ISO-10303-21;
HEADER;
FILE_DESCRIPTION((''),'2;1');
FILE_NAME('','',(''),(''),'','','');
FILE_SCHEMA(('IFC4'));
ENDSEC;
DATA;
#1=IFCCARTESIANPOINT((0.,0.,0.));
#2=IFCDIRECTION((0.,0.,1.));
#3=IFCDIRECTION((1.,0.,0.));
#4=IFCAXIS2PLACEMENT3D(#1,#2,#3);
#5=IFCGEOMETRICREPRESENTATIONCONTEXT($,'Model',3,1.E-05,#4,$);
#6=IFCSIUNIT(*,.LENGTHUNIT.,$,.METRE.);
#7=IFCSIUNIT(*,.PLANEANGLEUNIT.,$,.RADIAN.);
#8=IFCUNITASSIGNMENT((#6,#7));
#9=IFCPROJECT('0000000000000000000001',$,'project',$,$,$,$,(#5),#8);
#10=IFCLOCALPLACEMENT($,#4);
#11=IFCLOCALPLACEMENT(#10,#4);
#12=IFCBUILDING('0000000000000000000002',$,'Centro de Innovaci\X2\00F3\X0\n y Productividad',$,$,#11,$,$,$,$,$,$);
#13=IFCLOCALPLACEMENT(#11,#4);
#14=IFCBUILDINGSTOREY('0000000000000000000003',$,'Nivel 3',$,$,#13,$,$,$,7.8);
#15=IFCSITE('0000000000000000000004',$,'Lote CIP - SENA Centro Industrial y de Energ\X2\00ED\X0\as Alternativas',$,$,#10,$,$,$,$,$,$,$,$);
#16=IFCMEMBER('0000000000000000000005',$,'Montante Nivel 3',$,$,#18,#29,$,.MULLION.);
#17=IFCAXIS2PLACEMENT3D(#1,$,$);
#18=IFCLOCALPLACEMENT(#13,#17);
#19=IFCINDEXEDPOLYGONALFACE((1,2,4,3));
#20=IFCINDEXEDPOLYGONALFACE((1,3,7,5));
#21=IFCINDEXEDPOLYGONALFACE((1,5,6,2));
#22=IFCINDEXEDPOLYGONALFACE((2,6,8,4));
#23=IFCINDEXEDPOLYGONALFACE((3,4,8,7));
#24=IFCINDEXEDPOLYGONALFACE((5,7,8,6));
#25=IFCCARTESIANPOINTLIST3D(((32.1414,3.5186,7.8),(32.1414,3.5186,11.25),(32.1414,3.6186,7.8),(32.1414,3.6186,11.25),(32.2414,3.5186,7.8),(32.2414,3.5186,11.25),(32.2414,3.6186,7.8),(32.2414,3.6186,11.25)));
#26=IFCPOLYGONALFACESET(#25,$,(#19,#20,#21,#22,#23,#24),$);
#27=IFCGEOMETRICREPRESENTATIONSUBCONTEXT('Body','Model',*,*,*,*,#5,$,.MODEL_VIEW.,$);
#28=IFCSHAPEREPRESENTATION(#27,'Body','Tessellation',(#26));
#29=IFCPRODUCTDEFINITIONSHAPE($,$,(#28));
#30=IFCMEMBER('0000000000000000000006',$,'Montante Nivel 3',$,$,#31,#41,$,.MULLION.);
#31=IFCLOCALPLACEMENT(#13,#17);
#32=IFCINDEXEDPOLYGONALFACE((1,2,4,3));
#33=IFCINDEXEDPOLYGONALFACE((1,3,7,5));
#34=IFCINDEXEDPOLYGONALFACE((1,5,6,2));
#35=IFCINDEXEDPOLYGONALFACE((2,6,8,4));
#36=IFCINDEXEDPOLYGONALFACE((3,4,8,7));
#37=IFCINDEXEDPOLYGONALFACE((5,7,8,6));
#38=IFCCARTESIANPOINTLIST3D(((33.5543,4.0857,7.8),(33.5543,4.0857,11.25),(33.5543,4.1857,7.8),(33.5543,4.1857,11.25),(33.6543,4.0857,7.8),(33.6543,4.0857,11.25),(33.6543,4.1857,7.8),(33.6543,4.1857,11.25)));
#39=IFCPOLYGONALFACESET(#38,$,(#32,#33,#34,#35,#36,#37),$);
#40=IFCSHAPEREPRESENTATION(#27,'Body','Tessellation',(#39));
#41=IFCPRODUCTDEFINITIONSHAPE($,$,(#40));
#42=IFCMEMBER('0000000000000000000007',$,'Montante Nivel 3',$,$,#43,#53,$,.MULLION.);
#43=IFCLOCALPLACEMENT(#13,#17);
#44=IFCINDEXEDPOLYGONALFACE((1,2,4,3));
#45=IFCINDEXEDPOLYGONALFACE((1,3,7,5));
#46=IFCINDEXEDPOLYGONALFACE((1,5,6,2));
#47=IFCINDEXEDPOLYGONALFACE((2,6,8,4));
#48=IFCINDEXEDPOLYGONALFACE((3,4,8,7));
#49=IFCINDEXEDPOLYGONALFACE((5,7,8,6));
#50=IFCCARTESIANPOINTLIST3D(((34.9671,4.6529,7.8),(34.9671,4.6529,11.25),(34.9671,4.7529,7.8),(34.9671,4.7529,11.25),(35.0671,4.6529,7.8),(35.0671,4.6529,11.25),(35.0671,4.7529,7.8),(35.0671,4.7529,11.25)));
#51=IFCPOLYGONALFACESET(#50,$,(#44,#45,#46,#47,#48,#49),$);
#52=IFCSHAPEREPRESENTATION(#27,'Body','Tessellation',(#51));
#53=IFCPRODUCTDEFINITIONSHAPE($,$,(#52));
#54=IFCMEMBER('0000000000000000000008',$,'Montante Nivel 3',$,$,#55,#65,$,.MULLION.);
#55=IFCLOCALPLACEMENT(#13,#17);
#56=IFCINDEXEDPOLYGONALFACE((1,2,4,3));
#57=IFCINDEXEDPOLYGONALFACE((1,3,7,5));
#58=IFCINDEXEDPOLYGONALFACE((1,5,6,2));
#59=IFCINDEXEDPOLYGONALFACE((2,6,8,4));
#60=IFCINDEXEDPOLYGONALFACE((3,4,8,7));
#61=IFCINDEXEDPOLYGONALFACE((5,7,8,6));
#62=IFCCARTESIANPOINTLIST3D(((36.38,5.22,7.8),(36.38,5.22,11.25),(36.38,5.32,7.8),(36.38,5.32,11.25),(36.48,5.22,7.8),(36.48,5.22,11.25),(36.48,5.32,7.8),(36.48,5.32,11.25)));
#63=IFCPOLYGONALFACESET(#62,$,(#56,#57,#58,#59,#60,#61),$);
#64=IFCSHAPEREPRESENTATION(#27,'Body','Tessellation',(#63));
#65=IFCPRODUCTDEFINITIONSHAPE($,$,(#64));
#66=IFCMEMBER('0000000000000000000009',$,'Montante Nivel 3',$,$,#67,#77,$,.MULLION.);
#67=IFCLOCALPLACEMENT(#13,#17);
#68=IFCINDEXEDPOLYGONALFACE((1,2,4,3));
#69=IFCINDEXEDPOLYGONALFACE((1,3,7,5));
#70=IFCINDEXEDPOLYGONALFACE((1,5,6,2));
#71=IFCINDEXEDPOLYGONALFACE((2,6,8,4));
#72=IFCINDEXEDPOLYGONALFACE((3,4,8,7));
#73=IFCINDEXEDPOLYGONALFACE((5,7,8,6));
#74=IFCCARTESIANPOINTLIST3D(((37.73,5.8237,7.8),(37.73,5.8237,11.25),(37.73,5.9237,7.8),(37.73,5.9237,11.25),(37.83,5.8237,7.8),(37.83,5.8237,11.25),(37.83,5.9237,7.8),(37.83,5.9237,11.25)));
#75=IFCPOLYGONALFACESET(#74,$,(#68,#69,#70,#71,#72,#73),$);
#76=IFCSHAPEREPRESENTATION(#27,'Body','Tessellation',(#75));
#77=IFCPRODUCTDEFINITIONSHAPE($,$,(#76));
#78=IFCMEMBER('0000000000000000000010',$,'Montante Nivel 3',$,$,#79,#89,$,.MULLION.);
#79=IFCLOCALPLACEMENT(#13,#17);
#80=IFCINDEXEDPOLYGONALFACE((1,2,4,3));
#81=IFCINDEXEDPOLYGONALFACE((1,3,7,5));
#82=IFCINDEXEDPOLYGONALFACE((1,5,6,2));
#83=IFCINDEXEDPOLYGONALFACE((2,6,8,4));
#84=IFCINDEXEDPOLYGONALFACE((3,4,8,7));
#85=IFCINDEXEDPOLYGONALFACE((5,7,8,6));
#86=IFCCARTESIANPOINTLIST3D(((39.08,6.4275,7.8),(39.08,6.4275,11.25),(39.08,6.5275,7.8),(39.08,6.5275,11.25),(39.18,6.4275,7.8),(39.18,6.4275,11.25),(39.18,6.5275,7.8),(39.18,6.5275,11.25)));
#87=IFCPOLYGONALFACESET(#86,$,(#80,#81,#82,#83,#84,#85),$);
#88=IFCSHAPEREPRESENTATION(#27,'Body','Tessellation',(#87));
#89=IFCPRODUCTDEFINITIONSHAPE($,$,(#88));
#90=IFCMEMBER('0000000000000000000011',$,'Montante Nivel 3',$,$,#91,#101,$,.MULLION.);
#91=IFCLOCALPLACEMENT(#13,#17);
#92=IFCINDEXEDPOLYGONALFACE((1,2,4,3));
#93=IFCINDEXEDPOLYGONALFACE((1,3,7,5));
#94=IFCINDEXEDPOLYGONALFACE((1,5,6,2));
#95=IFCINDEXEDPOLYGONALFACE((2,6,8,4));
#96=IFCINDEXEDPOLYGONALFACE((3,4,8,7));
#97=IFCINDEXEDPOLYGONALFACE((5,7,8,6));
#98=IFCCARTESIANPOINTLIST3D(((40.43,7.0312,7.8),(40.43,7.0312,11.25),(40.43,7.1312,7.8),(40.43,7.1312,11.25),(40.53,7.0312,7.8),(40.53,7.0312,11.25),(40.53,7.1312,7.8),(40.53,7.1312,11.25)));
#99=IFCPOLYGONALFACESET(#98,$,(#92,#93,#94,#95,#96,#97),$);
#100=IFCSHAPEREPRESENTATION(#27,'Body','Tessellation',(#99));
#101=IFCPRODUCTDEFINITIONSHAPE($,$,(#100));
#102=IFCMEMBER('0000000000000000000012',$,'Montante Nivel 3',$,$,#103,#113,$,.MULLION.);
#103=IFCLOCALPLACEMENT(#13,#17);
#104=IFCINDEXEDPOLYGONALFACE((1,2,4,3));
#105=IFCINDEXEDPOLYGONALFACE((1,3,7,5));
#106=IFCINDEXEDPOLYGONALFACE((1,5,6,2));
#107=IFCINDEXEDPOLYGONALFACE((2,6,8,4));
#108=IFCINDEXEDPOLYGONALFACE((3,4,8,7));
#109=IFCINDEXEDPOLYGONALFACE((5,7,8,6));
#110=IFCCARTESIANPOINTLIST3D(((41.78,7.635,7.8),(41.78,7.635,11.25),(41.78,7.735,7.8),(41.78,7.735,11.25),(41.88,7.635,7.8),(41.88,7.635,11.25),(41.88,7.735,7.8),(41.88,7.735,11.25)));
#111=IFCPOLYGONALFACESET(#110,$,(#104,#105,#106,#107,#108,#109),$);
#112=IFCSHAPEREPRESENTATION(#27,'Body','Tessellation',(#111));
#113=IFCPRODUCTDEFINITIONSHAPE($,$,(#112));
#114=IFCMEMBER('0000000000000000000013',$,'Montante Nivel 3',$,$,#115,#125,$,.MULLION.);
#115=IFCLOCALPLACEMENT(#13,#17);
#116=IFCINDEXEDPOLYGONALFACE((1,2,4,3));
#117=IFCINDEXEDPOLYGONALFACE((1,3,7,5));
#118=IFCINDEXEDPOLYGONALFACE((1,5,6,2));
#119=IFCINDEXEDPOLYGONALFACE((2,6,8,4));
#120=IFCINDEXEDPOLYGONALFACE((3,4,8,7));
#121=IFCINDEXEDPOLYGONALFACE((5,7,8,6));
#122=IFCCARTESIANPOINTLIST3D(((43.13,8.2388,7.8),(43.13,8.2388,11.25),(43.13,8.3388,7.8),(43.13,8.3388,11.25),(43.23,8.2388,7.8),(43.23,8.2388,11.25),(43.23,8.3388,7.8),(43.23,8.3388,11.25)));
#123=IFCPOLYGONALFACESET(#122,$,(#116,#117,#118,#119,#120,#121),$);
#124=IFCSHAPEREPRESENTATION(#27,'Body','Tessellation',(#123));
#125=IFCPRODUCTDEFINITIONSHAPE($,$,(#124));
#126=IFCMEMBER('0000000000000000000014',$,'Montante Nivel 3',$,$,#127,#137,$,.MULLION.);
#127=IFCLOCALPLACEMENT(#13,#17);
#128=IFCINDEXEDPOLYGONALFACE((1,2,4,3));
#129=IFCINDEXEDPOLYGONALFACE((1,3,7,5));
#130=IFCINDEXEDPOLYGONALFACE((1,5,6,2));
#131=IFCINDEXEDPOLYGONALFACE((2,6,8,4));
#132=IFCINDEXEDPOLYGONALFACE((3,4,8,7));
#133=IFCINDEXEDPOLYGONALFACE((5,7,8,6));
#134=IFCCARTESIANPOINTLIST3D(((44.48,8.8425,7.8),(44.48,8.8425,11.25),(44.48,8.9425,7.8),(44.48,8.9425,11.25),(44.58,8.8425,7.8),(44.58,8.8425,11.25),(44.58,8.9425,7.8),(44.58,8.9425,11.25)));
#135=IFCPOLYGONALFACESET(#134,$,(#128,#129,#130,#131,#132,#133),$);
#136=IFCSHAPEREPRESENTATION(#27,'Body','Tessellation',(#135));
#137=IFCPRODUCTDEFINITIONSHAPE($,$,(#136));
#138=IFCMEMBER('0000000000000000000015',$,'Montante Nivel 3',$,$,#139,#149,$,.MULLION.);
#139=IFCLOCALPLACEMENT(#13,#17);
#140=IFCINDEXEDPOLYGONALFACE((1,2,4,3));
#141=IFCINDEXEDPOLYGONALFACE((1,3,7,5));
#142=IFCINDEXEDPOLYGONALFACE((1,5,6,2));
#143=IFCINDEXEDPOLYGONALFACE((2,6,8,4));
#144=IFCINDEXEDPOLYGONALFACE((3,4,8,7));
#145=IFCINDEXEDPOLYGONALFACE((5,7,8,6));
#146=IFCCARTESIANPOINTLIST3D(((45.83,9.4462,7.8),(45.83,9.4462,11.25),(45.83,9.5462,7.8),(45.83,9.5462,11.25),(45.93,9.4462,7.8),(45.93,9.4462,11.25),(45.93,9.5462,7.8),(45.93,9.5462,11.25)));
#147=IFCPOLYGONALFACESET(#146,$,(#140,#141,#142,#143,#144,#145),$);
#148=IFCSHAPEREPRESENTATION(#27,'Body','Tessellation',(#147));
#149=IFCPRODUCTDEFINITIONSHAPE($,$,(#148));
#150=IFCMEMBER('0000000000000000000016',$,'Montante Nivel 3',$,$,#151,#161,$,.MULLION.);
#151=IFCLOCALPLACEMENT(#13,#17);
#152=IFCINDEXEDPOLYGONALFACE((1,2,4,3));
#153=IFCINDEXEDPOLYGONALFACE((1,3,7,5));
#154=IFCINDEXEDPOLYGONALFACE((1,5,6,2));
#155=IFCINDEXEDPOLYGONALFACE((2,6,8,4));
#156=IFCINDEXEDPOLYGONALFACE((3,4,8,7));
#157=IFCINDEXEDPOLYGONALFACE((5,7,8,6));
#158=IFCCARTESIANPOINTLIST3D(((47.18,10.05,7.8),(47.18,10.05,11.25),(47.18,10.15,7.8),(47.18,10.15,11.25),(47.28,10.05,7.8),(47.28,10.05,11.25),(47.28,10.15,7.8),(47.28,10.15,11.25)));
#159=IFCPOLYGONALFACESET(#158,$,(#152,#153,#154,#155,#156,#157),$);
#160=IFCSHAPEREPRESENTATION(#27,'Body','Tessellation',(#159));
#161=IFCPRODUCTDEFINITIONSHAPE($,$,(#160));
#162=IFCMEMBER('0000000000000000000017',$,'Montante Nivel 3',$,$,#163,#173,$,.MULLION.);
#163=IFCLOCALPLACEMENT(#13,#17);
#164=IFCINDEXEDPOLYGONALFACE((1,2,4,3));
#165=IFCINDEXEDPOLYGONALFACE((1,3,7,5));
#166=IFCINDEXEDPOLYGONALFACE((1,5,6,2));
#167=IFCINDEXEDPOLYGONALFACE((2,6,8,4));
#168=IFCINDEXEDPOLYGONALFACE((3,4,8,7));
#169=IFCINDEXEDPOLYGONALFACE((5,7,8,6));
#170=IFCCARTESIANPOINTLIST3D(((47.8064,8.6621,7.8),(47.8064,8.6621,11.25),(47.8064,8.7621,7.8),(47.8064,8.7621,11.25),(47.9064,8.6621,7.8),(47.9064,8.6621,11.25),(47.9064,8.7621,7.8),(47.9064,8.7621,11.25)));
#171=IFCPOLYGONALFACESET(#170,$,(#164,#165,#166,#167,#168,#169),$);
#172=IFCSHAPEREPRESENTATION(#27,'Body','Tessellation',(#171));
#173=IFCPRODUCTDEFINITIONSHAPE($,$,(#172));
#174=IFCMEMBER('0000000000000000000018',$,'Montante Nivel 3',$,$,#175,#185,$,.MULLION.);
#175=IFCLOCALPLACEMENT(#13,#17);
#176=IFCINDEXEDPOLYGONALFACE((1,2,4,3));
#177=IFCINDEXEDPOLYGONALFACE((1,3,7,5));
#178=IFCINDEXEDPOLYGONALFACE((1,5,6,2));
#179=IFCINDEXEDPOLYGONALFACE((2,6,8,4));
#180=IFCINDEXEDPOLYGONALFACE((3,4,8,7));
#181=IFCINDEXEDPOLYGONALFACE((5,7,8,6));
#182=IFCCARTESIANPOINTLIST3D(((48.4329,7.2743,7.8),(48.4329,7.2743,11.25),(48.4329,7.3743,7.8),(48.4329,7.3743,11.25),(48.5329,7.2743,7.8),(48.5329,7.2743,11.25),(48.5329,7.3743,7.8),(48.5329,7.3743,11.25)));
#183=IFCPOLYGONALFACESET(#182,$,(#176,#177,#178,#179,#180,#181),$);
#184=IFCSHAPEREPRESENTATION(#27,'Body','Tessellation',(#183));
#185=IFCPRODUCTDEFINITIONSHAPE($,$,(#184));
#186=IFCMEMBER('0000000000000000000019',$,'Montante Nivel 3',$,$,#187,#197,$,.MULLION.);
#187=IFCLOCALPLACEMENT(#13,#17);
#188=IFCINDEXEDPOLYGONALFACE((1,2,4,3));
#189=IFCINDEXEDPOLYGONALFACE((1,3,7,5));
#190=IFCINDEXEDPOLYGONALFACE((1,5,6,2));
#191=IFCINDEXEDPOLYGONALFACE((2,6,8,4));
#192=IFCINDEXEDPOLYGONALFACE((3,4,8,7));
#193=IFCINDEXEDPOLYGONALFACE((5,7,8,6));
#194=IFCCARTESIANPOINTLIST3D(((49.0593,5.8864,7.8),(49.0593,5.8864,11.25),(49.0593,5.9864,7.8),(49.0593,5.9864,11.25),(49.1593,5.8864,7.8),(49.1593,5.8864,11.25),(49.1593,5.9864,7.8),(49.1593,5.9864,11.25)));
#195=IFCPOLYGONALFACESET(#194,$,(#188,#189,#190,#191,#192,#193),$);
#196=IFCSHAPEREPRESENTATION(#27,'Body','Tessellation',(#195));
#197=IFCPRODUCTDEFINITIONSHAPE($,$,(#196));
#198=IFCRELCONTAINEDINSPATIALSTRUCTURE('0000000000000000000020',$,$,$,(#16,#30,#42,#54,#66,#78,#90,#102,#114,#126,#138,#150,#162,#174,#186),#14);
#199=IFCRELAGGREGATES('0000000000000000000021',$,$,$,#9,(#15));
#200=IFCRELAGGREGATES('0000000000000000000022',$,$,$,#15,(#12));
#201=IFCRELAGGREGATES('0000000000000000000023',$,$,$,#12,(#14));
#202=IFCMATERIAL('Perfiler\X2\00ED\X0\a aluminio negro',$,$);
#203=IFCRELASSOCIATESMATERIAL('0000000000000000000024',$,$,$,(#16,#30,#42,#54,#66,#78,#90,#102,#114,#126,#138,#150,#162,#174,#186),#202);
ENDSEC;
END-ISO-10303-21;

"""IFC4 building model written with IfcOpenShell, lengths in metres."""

from ifc_helpers import new_model, si_unit, frame, origin_with_axes, place, context, subcontext, project, spatial, polyline, outline, extrude, material, element, save


model = new_model("IFC4")

# Units and contexts
model_context = context("Model", 3, precision=1e-05, world=origin_with_axes())
body_context = subcontext(model_context, "Body", "Model", "MODEL_VIEW")
ifc_project = project(units=[si_unit("LENGTHUNIT", "METRE"), si_unit("PLANEANGLEUNIT", "RADIAN")], contexts=[model_context])

# Site, building, storey
site_placement = place(None, origin_with_axes())
site = spatial("IfcSite", under=ifc_project, at=site_placement, Name="Lote CIP - SENA Centro Industrial y de Energías Alternativas")
building_placement = place(site_placement, origin_with_axes())
building = spatial("IfcBuilding", under=site, at=building_placement, Name="Centro de Innovación y Productividad")
storey_placement = place(building_placement, origin_with_axes())
storey = spatial("IfcBuildingStorey", under=building, at=storey_placement, Name="Nivel 3", Elevation=7.8)

# Members
ifc_material_1 = material(Name="Perfilería aluminio negro")
member_1_placement = place(storey_placement, origin_with_axes())
element("IfcMember", 1, at=member_1_placement, inside=storey, material=ifc_material_1, Name="Montante Nivel 3", PredefinedType="MULLION", context=body_context, shape_type="SweptSolid", body=[
    extrude(outline(polyline([(32.2414, 3.6186), (32.2414, 3.5186), (32.1414, 3.5186), (32.1414, 3.6186), (32.2414, 3.6186)])), frame((0.0, 0.0, 7.8)), (0.0, 0.0, 1.0), 3.45),
])
member_2_placement = place(storey_placement, origin_with_axes())
element("IfcMember", 2, at=member_2_placement, inside=storey, material=ifc_material_1, Name="Montante Nivel 3", PredefinedType="MULLION", context=body_context, shape_type="SweptSolid", body=[
    extrude(outline(polyline([(33.6543, 4.1857), (33.6543, 4.0857), (33.5543, 4.0857), (33.5543, 4.1857), (33.6543, 4.1857)])), frame((0.0, 0.0, 7.8)), (0.0, 0.0, 1.0), 3.45),
])
member_3_placement = place(storey_placement, origin_with_axes())
element("IfcMember", 3, at=member_3_placement, inside=storey, material=ifc_material_1, Name="Montante Nivel 3", PredefinedType="MULLION", context=body_context, shape_type="SweptSolid", body=[
    extrude(outline(polyline([(35.0671, 4.7529), (35.0671, 4.6529), (34.9671, 4.6529), (34.9671, 4.7529), (35.0671, 4.7529)])), frame((0.0, 0.0, 7.8)), (0.0, 0.0, 1.0), 3.45),
])
for number, where, z_axis, x_axis, name in (
    (4, (0.0, 0.0, 0.0), (0.0, 0.0, 1.0), (1.0, 0.0, 0.0), "Montante Nivel 3"),
):
    element("IfcMember", number, at=place(storey_placement, frame(where, z_axis=z_axis, x_axis=x_axis)), inside=storey, material=ifc_material_1, Name=name, PredefinedType="MULLION", context=body_context, shape_type="SweptSolid", body=[
        extrude(outline(polyline([(36.48, 5.32), (36.48, 5.22), (36.38, 5.22), (36.38, 5.32), (36.48, 5.32)])), frame((0.0, 0.0, 7.8)), (0.0, 0.0, 1.0), 3.45),
    ])
member_4_placement = place(storey_placement, origin_with_axes())
element("IfcMember", 5, at=member_4_placement, inside=storey, material=ifc_material_1, Name="Montante Nivel 3", PredefinedType="MULLION", context=body_context, shape_type="SweptSolid", body=[
    extrude(outline(polyline([(37.83, 5.9237), (37.83, 5.8237), (37.73, 5.8237), (37.73, 5.9237), (37.83, 5.9237)])), frame((0.0, 0.0, 7.8)), (0.0, 0.0, 1.0), 3.45),
])
member_5_placement = place(storey_placement, origin_with_axes())
element("IfcMember", 6, at=member_5_placement, inside=storey, material=ifc_material_1, Name="Montante Nivel 3", PredefinedType="MULLION", context=body_context, shape_type="SweptSolid", body=[
    extrude(outline(polyline([(39.18, 6.5275), (39.18, 6.4275), (39.08, 6.4275), (39.08, 6.5275), (39.18, 6.5275)])), frame((0.0, 0.0, 7.8)), (0.0, 0.0, 1.0), 3.45),
])
member_6_placement = place(storey_placement, origin_with_axes())
element("IfcMember", 7, at=member_6_placement, inside=storey, material=ifc_material_1, Name="Montante Nivel 3", PredefinedType="MULLION", context=body_context, shape_type="SweptSolid", body=[
    extrude(outline(polyline([(40.53, 7.1312), (40.53, 7.0312), (40.43, 7.0312), (40.43, 7.1312), (40.53, 7.1312)])), frame((0.0, 0.0, 7.8)), (0.0, 0.0, 1.0), 3.45),
])
member_7_placement = place(storey_placement, origin_with_axes())
element("IfcMember", 8, at=member_7_placement, inside=storey, material=ifc_material_1, Name="Montante Nivel 3", PredefinedType="MULLION", context=body_context, shape_type="SweptSolid", body=[
    extrude(outline(polyline([(41.88, 7.735), (41.88, 7.635), (41.78, 7.635), (41.78, 7.735), (41.88, 7.735)])), frame((0.0, 0.0, 7.8)), (0.0, 0.0, 1.0), 3.45),
])
member_8_placement = place(storey_placement, origin_with_axes())
element("IfcMember", 9, at=member_8_placement, inside=storey, material=ifc_material_1, Name="Montante Nivel 3", PredefinedType="MULLION", context=body_context, shape_type="SweptSolid", body=[
    extrude(outline(polyline([(43.23, 8.3388), (43.23, 8.2387), (43.13, 8.2387), (43.13, 8.3388), (43.23, 8.3388)])), frame((0.0, 0.0, 7.8)), (0.0, 0.0, 1.0), 3.45),
])
member_9_placement = place(storey_placement, origin_with_axes())
element("IfcMember", 10, at=member_9_placement, inside=storey, material=ifc_material_1, Name="Montante Nivel 3", PredefinedType="MULLION", context=body_context, shape_type="SweptSolid", body=[
    extrude(outline(polyline([(44.58, 8.9425), (44.58, 8.8425), (44.48, 8.8425), (44.48, 8.9425), (44.58, 8.9425)])), frame((0.0, 0.0, 7.8)), (0.0, 0.0, 1.0), 3.45),
])
member_10_placement = place(storey_placement, origin_with_axes())
element("IfcMember", 11, at=member_10_placement, inside=storey, material=ifc_material_1, Name="Montante Nivel 3", PredefinedType="MULLION", context=body_context, shape_type="SweptSolid", body=[
    extrude(outline(polyline([(45.93, 9.5463), (45.93, 9.4462), (45.83, 9.4462), (45.83, 9.5463), (45.93, 9.5463)])), frame((0.0, 0.0, 7.8)), (0.0, 0.0, 1.0), 3.45),
])
for number, where, z_axis, x_axis, name in (
    (12, (0.0, 0.0, 0.0), (0.0, 0.0, 1.0), (1.0, 0.0, 0.0), "Montante Nivel 3"),
):
    element("IfcMember", number, at=place(storey_placement, frame(where, z_axis=z_axis, x_axis=x_axis)), inside=storey, material=ifc_material_1, Name=name, PredefinedType="MULLION", context=body_context, shape_type="SweptSolid", body=[
        extrude(outline(polyline([(47.28, 10.15), (47.28, 10.05), (47.18, 10.05), (47.18, 10.15), (47.28, 10.15)])), frame((0.0, 0.0, 7.8)), (0.0, 0.0, 1.0), 3.45),
    ])
member_11_placement = place(storey_placement, origin_with_axes())
element("IfcMember", 13, at=member_11_placement, inside=storey, material=ifc_material_1, Name="Montante Nivel 3", PredefinedType="MULLION", context=body_context, shape_type="SweptSolid", body=[
    extrude(outline(polyline([(47.9064, 8.7621), (47.9064, 8.6621), (47.8064, 8.6621), (47.8064, 8.7621), (47.9064, 8.7621)])), frame((0.0, 0.0, 7.8)), (0.0, 0.0, 1.0), 3.45),
])
member_12_placement = place(storey_placement, origin_with_axes())
element("IfcMember", 14, at=member_12_placement, inside=storey, material=ifc_material_1, Name="Montante Nivel 3", PredefinedType="MULLION", context=body_context, shape_type="SweptSolid", body=[
    extrude(outline(polyline([(48.5329, 7.3743), (48.5329, 7.2743), (48.4329, 7.2743), (48.4329, 7.3743), (48.5329, 7.3743)])), frame((0.0, 0.0, 7.8)), (0.0, 0.0, 1.0), 3.45),
])
member_13_placement = place(storey_placement, origin_with_axes())
element("IfcMember", 15, at=member_13_placement, inside=storey, material=ifc_material_1, Name="Montante Nivel 3", PredefinedType="MULLION", context=body_context, shape_type="SweptSolid", body=[
    extrude(outline(polyline([(49.1593, 5.9864), (49.1593, 5.8864), (49.0593, 5.8864), (49.0593, 5.9864), (49.1593, 5.9864)])), frame((0.0, 0.0, 7.8)), (0.0, 0.0, 1.0), 3.45),
])

save(model, "model.ifc")
